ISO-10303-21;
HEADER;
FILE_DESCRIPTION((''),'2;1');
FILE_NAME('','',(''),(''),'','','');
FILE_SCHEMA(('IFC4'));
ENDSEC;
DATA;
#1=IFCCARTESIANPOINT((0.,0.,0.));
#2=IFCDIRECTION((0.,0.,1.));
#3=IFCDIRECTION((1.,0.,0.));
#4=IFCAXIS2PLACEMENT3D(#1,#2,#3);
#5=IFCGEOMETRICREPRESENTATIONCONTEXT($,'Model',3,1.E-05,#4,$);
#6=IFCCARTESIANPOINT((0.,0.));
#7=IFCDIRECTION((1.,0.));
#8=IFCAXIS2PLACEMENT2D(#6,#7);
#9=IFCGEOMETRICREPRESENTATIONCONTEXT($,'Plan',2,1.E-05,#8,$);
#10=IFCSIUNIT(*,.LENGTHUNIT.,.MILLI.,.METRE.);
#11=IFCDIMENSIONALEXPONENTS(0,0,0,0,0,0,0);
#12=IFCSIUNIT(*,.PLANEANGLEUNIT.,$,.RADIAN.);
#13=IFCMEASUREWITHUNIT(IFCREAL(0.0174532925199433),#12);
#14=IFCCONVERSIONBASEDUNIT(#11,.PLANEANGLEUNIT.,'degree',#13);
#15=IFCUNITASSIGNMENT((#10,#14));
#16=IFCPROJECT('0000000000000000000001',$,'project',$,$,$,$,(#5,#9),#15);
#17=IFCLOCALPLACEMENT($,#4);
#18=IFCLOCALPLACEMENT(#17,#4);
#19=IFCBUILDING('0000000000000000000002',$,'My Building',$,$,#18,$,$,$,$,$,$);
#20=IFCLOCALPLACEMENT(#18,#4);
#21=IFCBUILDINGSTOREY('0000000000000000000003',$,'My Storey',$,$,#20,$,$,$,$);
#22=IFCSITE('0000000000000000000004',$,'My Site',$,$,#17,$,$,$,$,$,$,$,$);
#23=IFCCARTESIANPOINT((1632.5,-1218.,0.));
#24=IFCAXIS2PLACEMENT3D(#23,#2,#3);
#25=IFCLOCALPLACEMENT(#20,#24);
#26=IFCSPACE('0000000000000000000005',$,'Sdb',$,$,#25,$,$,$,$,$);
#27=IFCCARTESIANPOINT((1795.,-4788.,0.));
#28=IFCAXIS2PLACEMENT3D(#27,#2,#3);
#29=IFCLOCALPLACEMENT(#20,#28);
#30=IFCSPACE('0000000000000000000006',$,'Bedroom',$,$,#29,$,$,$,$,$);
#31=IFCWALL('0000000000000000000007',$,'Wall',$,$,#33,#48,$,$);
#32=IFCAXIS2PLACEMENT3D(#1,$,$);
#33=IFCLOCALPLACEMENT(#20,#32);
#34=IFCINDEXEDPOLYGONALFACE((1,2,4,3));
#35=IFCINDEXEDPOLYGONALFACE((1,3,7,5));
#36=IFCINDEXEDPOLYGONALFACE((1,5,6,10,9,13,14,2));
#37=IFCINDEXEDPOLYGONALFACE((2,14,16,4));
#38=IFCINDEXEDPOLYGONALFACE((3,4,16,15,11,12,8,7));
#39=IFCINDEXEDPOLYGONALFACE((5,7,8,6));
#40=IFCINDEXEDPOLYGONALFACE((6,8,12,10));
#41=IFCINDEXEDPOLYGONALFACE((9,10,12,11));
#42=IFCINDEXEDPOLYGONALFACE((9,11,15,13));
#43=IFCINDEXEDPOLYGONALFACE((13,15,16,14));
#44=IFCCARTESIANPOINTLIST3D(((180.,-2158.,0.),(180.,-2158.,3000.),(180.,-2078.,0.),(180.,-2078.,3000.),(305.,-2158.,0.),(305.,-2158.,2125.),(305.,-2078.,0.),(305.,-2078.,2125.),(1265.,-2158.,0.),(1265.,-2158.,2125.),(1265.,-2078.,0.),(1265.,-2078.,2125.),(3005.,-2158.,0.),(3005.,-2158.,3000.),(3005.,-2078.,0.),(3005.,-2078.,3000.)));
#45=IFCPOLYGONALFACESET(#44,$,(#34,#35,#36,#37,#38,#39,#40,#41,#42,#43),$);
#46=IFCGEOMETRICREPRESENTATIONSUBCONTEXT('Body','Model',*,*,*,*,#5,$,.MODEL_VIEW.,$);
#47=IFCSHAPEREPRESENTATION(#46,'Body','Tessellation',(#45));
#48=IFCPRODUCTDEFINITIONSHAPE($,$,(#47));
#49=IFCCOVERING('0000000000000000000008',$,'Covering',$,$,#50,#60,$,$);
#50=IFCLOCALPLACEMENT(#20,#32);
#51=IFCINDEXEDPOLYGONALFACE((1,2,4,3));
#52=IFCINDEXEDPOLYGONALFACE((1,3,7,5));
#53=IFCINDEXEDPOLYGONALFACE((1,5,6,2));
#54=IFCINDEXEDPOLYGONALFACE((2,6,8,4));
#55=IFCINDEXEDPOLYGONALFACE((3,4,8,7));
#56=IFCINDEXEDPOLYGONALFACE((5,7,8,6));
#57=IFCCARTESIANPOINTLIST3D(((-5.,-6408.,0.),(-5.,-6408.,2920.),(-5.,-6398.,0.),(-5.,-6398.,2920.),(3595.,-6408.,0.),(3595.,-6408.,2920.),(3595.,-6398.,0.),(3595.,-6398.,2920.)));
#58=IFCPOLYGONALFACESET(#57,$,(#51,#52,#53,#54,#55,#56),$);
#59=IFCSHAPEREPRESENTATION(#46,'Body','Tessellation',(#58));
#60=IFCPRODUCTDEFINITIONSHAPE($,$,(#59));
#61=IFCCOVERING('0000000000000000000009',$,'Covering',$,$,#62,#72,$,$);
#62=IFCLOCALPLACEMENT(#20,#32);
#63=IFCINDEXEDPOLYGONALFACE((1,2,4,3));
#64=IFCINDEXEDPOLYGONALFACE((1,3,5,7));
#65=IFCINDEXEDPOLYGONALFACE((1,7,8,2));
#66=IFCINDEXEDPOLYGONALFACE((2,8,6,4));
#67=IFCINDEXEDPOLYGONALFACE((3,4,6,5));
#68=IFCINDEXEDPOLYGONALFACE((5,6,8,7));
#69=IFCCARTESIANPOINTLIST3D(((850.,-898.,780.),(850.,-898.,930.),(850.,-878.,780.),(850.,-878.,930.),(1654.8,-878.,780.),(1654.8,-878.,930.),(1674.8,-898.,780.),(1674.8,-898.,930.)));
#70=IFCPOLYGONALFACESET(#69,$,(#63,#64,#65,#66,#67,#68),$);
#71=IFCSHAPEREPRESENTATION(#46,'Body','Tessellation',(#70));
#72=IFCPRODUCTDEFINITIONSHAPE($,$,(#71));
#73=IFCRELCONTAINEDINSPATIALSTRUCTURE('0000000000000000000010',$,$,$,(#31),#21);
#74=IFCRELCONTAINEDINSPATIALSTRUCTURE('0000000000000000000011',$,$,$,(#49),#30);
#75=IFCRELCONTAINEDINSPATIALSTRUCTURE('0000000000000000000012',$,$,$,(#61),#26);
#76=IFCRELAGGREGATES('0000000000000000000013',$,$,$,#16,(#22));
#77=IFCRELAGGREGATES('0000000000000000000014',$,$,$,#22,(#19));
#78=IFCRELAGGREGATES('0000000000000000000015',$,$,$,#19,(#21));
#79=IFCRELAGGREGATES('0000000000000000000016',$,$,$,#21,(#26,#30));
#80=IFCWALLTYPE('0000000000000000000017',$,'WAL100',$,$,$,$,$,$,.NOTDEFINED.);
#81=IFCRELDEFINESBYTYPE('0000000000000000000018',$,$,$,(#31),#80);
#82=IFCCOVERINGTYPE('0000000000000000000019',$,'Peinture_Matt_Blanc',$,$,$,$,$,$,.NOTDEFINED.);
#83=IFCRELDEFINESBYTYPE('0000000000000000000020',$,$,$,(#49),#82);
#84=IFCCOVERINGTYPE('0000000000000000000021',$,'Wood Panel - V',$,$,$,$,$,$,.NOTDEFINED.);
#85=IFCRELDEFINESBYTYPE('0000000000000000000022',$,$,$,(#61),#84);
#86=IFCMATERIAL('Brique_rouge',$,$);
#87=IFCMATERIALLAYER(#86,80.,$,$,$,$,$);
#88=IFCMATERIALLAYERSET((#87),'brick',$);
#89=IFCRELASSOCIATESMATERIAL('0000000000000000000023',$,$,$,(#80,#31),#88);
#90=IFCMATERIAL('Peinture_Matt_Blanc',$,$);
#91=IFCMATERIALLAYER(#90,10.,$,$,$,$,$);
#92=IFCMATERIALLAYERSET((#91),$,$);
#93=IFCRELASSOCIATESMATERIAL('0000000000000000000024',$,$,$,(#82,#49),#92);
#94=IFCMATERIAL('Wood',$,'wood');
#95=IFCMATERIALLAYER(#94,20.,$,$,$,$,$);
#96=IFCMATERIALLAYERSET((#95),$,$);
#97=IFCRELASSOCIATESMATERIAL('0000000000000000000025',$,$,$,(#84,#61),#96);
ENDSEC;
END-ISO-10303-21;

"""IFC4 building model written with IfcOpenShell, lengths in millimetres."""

from ifc_helpers import new_model, entity, si_unit, converted_unit, frame, origin_with_axes, origin_2d_with_axis, place, context, subcontext, project, spatial, line, indexed_curve, outline, extrude, clip, halfspace, source, transform, mapped, material, layer, layer_set, layer_usage, type_object, element, save


model = new_model("IFC4")

# Units and contexts
model_context = context("Model", 3, precision=1e-05, world=origin_with_axes())
plan_context = context("Plan", 2, precision=1e-05, world=origin_2d_with_axis())
body_context = subcontext(model_context, "Body", "Model", "MODEL_VIEW")
ifc_project = project(units=[si_unit("LENGTHUNIT", "METRE", prefix="MILLI"), converted_unit("PLANEANGLEUNIT", "degree", entity("IfcReal", 0.0174532925199433), si_unit("PLANEANGLEUNIT", "RADIAN"), dimensions=[0, 0, 0, 0, 0, 0, 0])], contexts=[model_context, plan_context])

# Site, building, storey, space
site_placement = place(None, origin_with_axes())
site = spatial("IfcSite", under=ifc_project, at=site_placement, Name="My Site")
building_placement = place(site_placement, origin_with_axes())
building = spatial("IfcBuilding", under=site, at=building_placement, Name="My Building")
storey_placement = place(building_placement, origin_with_axes())
storey = spatial("IfcBuildingStorey", under=building, at=storey_placement, Name="My Storey")
space_1_placement = place(storey_placement, frame((1632.5, -1218.0, 0.0), z_axis=(0.0, 0.0, 1.0), x_axis=(1.0, 0.0, 0.0)))
space_1 = spatial("IfcSpace", under=storey, at=space_1_placement, Name="Sdb")

# Wall, opening
ifc_material_1 = material(Name="Brique_rouge")
ifc_layer_1 = layer(ifc_material_1, 80.0)
ifc_layer_set_1 = layer_set([ifc_layer_1], Name="brick")
ifc_layer_usage_1 = layer_usage(ifc_layer_set_1, "AXIS2", "POSITIVE", 0.0)
wall_type = type_object("IfcWallType", Name="WAL100", PredefinedType="NOTDEFINED", material=ifc_layer_set_1)
wall_placement = place(storey_placement, frame((180.0, -2158.0, 0.0), z_axis=(0.0, 0.0, 1.0), x_axis=(1.0, -0.000001, 0.0)))
wall = element("IfcWall", 1, at=wall_placement, inside=storey, type_object=wall_type, material=ifc_layer_usage_1, Name="Wall", context=body_context, shape_type="SweptSolid", body=[
    extrude(outline(indexed_curve([(0.0, 0.0), (0.0, 80.0), (2825.0, 80.0), (2825.0, 0.0), (0.0, 0.0)], self_intersect=False)), origin_with_axes(), (0.0, 0.0, 1.0), 3000.0),
])
shared_shape_1 = source(origin_with_axes(), body_context, "Body", "SweptSolid", [
    extrude(outline(indexed_curve([(960.0, 2125.0), (960.0, 0.0), (0.0, 0.0), (0.0, 2125.0)], segments=[line(4, 1), line(1, 2), line(2, 3), line(3, 4)], self_intersect=False)), frame((0.0, -100.0, 0.0), z_axis=(0.0, -1.0, 0.0), x_axis=(1.0, 0.0, 0.0)), (0.0, 0.0, -1.0), 300.0),
])
opening_1_placement = place(wall_placement, frame((125.0, 0.0, 0.0), z_axis=(0.0, 0.0, 1.0), x_axis=(1.0, 0.0, 0.0)))
element("IfcOpeningElement", 2, at=opening_1_placement, cuts=wall, PredefinedType="OPENING", context=body_context, shape_type="MappedRepresentation", body=[
    mapped(shared_shape_1, transform((0.0, 0.0, 0.0), x_axis=(1.0, 0.0, 0.0), y_axis=(0.0, 1.0, 0.0), z_axis=(0.0, 0.0, 1.0), scale=1.0)),
])

# Shared definitions
space_2_placement = place(storey_placement, frame((1795.0, -4788.0, 0.0), z_axis=(0.0, 0.0, 1.0), x_axis=(1.0, 0.0, 0.0)))
space_2 = spatial("IfcSpace", under=storey, at=space_2_placement, Name="Bedroom")

# Coverings
ifc_material_2 = material(Name="Peinture_Matt_Blanc")
ifc_layer_2 = layer(ifc_material_2, 10.0)
ifc_layer_set_2 = layer_set([ifc_layer_2])
ifc_layer_usage_2 = layer_usage(ifc_layer_set_2, "AXIS2", "POSITIVE", 0.0)
covering_type_1 = type_object("IfcCoveringType", Name="Peinture_Matt_Blanc", PredefinedType="NOTDEFINED", material=ifc_layer_set_2)
covering_1_placement = place(space_2_placement, frame((-1800.0, -1620.0, 0.0), z_axis=(0.0, 0.0, 1.0), x_axis=(1.0, -0.000002, 0.0)))
element("IfcCovering", 3, at=covering_1_placement, inside=space_2, type_object=covering_type_1, material=ifc_layer_usage_2, Name="Covering", context=body_context, shape_type="Clipping", body=[
    clip(clip(extrude(outline(indexed_curve([(0.0, 0.0), (0.0, 10.0), (3600.0, 10.0), (3600.0, 0.0), (0.0, 0.0)], self_intersect=False)), origin_with_axes(), (0.0, 0.0, 1.0), 2920.0), halfspace(frame((0.0, 0.0, 2920.0), z_axis=(0.0, 0.0, 1.0), x_axis=(-1.0, 0.0, 0.0)), False)), halfspace(frame((0.0, 0.0, 2920.0), z_axis=(0.0, 0.0, 1.0), x_axis=(-1.0, 0.0, 0.0)), False)),
])
ifc_material_3 = material(Name="Wood", Category="wood")
ifc_layer_3 = layer(ifc_material_3, 20.0)
ifc_layer_set_3 = layer_set([ifc_layer_3])
covering_type_2 = type_object("IfcCoveringType", Name="Wood Panel - V", PredefinedType="NOTDEFINED", material=ifc_layer_set_3)
ifc_layer_usage_3 = layer_usage(ifc_layer_set_3, "AXIS2", "POSITIVE", 0.0)
covering_2_placement = place(space_1_placement, frame((-782.5, 320.0, 780.0), z_axis=(0.0, 0.0, 1.0), x_axis=(1.0, -0.000001, 0.0)))
element("IfcCovering", 4, at=covering_2_placement, inside=space_1, type_object=covering_type_2, material=ifc_layer_usage_3, Name="Covering", context=body_context, shape_type="Clipping", body=[
    clip(clip(extrude(outline(indexed_curve([(0.0, 0.0), (0.0, 20.0), (824.8, 20.0), (824.8, 0.0), (0.0, 0.0)], self_intersect=False)), origin_with_axes(), (0.0, 0.0, 1.0), 930.0), halfspace(frame((0.0, 0.0, 150.0), z_axis=(0.0, 0.0, 1.0), x_axis=(-1.0, 0.0, 0.0)), False)), halfspace(frame((824.8, 0.0, -780.0), z_axis=(0.707106, 0.707107, 0.0), x_axis=(0.707107, -0.707106, 0.0)), False)),
])

save(model, "model.ifc")
